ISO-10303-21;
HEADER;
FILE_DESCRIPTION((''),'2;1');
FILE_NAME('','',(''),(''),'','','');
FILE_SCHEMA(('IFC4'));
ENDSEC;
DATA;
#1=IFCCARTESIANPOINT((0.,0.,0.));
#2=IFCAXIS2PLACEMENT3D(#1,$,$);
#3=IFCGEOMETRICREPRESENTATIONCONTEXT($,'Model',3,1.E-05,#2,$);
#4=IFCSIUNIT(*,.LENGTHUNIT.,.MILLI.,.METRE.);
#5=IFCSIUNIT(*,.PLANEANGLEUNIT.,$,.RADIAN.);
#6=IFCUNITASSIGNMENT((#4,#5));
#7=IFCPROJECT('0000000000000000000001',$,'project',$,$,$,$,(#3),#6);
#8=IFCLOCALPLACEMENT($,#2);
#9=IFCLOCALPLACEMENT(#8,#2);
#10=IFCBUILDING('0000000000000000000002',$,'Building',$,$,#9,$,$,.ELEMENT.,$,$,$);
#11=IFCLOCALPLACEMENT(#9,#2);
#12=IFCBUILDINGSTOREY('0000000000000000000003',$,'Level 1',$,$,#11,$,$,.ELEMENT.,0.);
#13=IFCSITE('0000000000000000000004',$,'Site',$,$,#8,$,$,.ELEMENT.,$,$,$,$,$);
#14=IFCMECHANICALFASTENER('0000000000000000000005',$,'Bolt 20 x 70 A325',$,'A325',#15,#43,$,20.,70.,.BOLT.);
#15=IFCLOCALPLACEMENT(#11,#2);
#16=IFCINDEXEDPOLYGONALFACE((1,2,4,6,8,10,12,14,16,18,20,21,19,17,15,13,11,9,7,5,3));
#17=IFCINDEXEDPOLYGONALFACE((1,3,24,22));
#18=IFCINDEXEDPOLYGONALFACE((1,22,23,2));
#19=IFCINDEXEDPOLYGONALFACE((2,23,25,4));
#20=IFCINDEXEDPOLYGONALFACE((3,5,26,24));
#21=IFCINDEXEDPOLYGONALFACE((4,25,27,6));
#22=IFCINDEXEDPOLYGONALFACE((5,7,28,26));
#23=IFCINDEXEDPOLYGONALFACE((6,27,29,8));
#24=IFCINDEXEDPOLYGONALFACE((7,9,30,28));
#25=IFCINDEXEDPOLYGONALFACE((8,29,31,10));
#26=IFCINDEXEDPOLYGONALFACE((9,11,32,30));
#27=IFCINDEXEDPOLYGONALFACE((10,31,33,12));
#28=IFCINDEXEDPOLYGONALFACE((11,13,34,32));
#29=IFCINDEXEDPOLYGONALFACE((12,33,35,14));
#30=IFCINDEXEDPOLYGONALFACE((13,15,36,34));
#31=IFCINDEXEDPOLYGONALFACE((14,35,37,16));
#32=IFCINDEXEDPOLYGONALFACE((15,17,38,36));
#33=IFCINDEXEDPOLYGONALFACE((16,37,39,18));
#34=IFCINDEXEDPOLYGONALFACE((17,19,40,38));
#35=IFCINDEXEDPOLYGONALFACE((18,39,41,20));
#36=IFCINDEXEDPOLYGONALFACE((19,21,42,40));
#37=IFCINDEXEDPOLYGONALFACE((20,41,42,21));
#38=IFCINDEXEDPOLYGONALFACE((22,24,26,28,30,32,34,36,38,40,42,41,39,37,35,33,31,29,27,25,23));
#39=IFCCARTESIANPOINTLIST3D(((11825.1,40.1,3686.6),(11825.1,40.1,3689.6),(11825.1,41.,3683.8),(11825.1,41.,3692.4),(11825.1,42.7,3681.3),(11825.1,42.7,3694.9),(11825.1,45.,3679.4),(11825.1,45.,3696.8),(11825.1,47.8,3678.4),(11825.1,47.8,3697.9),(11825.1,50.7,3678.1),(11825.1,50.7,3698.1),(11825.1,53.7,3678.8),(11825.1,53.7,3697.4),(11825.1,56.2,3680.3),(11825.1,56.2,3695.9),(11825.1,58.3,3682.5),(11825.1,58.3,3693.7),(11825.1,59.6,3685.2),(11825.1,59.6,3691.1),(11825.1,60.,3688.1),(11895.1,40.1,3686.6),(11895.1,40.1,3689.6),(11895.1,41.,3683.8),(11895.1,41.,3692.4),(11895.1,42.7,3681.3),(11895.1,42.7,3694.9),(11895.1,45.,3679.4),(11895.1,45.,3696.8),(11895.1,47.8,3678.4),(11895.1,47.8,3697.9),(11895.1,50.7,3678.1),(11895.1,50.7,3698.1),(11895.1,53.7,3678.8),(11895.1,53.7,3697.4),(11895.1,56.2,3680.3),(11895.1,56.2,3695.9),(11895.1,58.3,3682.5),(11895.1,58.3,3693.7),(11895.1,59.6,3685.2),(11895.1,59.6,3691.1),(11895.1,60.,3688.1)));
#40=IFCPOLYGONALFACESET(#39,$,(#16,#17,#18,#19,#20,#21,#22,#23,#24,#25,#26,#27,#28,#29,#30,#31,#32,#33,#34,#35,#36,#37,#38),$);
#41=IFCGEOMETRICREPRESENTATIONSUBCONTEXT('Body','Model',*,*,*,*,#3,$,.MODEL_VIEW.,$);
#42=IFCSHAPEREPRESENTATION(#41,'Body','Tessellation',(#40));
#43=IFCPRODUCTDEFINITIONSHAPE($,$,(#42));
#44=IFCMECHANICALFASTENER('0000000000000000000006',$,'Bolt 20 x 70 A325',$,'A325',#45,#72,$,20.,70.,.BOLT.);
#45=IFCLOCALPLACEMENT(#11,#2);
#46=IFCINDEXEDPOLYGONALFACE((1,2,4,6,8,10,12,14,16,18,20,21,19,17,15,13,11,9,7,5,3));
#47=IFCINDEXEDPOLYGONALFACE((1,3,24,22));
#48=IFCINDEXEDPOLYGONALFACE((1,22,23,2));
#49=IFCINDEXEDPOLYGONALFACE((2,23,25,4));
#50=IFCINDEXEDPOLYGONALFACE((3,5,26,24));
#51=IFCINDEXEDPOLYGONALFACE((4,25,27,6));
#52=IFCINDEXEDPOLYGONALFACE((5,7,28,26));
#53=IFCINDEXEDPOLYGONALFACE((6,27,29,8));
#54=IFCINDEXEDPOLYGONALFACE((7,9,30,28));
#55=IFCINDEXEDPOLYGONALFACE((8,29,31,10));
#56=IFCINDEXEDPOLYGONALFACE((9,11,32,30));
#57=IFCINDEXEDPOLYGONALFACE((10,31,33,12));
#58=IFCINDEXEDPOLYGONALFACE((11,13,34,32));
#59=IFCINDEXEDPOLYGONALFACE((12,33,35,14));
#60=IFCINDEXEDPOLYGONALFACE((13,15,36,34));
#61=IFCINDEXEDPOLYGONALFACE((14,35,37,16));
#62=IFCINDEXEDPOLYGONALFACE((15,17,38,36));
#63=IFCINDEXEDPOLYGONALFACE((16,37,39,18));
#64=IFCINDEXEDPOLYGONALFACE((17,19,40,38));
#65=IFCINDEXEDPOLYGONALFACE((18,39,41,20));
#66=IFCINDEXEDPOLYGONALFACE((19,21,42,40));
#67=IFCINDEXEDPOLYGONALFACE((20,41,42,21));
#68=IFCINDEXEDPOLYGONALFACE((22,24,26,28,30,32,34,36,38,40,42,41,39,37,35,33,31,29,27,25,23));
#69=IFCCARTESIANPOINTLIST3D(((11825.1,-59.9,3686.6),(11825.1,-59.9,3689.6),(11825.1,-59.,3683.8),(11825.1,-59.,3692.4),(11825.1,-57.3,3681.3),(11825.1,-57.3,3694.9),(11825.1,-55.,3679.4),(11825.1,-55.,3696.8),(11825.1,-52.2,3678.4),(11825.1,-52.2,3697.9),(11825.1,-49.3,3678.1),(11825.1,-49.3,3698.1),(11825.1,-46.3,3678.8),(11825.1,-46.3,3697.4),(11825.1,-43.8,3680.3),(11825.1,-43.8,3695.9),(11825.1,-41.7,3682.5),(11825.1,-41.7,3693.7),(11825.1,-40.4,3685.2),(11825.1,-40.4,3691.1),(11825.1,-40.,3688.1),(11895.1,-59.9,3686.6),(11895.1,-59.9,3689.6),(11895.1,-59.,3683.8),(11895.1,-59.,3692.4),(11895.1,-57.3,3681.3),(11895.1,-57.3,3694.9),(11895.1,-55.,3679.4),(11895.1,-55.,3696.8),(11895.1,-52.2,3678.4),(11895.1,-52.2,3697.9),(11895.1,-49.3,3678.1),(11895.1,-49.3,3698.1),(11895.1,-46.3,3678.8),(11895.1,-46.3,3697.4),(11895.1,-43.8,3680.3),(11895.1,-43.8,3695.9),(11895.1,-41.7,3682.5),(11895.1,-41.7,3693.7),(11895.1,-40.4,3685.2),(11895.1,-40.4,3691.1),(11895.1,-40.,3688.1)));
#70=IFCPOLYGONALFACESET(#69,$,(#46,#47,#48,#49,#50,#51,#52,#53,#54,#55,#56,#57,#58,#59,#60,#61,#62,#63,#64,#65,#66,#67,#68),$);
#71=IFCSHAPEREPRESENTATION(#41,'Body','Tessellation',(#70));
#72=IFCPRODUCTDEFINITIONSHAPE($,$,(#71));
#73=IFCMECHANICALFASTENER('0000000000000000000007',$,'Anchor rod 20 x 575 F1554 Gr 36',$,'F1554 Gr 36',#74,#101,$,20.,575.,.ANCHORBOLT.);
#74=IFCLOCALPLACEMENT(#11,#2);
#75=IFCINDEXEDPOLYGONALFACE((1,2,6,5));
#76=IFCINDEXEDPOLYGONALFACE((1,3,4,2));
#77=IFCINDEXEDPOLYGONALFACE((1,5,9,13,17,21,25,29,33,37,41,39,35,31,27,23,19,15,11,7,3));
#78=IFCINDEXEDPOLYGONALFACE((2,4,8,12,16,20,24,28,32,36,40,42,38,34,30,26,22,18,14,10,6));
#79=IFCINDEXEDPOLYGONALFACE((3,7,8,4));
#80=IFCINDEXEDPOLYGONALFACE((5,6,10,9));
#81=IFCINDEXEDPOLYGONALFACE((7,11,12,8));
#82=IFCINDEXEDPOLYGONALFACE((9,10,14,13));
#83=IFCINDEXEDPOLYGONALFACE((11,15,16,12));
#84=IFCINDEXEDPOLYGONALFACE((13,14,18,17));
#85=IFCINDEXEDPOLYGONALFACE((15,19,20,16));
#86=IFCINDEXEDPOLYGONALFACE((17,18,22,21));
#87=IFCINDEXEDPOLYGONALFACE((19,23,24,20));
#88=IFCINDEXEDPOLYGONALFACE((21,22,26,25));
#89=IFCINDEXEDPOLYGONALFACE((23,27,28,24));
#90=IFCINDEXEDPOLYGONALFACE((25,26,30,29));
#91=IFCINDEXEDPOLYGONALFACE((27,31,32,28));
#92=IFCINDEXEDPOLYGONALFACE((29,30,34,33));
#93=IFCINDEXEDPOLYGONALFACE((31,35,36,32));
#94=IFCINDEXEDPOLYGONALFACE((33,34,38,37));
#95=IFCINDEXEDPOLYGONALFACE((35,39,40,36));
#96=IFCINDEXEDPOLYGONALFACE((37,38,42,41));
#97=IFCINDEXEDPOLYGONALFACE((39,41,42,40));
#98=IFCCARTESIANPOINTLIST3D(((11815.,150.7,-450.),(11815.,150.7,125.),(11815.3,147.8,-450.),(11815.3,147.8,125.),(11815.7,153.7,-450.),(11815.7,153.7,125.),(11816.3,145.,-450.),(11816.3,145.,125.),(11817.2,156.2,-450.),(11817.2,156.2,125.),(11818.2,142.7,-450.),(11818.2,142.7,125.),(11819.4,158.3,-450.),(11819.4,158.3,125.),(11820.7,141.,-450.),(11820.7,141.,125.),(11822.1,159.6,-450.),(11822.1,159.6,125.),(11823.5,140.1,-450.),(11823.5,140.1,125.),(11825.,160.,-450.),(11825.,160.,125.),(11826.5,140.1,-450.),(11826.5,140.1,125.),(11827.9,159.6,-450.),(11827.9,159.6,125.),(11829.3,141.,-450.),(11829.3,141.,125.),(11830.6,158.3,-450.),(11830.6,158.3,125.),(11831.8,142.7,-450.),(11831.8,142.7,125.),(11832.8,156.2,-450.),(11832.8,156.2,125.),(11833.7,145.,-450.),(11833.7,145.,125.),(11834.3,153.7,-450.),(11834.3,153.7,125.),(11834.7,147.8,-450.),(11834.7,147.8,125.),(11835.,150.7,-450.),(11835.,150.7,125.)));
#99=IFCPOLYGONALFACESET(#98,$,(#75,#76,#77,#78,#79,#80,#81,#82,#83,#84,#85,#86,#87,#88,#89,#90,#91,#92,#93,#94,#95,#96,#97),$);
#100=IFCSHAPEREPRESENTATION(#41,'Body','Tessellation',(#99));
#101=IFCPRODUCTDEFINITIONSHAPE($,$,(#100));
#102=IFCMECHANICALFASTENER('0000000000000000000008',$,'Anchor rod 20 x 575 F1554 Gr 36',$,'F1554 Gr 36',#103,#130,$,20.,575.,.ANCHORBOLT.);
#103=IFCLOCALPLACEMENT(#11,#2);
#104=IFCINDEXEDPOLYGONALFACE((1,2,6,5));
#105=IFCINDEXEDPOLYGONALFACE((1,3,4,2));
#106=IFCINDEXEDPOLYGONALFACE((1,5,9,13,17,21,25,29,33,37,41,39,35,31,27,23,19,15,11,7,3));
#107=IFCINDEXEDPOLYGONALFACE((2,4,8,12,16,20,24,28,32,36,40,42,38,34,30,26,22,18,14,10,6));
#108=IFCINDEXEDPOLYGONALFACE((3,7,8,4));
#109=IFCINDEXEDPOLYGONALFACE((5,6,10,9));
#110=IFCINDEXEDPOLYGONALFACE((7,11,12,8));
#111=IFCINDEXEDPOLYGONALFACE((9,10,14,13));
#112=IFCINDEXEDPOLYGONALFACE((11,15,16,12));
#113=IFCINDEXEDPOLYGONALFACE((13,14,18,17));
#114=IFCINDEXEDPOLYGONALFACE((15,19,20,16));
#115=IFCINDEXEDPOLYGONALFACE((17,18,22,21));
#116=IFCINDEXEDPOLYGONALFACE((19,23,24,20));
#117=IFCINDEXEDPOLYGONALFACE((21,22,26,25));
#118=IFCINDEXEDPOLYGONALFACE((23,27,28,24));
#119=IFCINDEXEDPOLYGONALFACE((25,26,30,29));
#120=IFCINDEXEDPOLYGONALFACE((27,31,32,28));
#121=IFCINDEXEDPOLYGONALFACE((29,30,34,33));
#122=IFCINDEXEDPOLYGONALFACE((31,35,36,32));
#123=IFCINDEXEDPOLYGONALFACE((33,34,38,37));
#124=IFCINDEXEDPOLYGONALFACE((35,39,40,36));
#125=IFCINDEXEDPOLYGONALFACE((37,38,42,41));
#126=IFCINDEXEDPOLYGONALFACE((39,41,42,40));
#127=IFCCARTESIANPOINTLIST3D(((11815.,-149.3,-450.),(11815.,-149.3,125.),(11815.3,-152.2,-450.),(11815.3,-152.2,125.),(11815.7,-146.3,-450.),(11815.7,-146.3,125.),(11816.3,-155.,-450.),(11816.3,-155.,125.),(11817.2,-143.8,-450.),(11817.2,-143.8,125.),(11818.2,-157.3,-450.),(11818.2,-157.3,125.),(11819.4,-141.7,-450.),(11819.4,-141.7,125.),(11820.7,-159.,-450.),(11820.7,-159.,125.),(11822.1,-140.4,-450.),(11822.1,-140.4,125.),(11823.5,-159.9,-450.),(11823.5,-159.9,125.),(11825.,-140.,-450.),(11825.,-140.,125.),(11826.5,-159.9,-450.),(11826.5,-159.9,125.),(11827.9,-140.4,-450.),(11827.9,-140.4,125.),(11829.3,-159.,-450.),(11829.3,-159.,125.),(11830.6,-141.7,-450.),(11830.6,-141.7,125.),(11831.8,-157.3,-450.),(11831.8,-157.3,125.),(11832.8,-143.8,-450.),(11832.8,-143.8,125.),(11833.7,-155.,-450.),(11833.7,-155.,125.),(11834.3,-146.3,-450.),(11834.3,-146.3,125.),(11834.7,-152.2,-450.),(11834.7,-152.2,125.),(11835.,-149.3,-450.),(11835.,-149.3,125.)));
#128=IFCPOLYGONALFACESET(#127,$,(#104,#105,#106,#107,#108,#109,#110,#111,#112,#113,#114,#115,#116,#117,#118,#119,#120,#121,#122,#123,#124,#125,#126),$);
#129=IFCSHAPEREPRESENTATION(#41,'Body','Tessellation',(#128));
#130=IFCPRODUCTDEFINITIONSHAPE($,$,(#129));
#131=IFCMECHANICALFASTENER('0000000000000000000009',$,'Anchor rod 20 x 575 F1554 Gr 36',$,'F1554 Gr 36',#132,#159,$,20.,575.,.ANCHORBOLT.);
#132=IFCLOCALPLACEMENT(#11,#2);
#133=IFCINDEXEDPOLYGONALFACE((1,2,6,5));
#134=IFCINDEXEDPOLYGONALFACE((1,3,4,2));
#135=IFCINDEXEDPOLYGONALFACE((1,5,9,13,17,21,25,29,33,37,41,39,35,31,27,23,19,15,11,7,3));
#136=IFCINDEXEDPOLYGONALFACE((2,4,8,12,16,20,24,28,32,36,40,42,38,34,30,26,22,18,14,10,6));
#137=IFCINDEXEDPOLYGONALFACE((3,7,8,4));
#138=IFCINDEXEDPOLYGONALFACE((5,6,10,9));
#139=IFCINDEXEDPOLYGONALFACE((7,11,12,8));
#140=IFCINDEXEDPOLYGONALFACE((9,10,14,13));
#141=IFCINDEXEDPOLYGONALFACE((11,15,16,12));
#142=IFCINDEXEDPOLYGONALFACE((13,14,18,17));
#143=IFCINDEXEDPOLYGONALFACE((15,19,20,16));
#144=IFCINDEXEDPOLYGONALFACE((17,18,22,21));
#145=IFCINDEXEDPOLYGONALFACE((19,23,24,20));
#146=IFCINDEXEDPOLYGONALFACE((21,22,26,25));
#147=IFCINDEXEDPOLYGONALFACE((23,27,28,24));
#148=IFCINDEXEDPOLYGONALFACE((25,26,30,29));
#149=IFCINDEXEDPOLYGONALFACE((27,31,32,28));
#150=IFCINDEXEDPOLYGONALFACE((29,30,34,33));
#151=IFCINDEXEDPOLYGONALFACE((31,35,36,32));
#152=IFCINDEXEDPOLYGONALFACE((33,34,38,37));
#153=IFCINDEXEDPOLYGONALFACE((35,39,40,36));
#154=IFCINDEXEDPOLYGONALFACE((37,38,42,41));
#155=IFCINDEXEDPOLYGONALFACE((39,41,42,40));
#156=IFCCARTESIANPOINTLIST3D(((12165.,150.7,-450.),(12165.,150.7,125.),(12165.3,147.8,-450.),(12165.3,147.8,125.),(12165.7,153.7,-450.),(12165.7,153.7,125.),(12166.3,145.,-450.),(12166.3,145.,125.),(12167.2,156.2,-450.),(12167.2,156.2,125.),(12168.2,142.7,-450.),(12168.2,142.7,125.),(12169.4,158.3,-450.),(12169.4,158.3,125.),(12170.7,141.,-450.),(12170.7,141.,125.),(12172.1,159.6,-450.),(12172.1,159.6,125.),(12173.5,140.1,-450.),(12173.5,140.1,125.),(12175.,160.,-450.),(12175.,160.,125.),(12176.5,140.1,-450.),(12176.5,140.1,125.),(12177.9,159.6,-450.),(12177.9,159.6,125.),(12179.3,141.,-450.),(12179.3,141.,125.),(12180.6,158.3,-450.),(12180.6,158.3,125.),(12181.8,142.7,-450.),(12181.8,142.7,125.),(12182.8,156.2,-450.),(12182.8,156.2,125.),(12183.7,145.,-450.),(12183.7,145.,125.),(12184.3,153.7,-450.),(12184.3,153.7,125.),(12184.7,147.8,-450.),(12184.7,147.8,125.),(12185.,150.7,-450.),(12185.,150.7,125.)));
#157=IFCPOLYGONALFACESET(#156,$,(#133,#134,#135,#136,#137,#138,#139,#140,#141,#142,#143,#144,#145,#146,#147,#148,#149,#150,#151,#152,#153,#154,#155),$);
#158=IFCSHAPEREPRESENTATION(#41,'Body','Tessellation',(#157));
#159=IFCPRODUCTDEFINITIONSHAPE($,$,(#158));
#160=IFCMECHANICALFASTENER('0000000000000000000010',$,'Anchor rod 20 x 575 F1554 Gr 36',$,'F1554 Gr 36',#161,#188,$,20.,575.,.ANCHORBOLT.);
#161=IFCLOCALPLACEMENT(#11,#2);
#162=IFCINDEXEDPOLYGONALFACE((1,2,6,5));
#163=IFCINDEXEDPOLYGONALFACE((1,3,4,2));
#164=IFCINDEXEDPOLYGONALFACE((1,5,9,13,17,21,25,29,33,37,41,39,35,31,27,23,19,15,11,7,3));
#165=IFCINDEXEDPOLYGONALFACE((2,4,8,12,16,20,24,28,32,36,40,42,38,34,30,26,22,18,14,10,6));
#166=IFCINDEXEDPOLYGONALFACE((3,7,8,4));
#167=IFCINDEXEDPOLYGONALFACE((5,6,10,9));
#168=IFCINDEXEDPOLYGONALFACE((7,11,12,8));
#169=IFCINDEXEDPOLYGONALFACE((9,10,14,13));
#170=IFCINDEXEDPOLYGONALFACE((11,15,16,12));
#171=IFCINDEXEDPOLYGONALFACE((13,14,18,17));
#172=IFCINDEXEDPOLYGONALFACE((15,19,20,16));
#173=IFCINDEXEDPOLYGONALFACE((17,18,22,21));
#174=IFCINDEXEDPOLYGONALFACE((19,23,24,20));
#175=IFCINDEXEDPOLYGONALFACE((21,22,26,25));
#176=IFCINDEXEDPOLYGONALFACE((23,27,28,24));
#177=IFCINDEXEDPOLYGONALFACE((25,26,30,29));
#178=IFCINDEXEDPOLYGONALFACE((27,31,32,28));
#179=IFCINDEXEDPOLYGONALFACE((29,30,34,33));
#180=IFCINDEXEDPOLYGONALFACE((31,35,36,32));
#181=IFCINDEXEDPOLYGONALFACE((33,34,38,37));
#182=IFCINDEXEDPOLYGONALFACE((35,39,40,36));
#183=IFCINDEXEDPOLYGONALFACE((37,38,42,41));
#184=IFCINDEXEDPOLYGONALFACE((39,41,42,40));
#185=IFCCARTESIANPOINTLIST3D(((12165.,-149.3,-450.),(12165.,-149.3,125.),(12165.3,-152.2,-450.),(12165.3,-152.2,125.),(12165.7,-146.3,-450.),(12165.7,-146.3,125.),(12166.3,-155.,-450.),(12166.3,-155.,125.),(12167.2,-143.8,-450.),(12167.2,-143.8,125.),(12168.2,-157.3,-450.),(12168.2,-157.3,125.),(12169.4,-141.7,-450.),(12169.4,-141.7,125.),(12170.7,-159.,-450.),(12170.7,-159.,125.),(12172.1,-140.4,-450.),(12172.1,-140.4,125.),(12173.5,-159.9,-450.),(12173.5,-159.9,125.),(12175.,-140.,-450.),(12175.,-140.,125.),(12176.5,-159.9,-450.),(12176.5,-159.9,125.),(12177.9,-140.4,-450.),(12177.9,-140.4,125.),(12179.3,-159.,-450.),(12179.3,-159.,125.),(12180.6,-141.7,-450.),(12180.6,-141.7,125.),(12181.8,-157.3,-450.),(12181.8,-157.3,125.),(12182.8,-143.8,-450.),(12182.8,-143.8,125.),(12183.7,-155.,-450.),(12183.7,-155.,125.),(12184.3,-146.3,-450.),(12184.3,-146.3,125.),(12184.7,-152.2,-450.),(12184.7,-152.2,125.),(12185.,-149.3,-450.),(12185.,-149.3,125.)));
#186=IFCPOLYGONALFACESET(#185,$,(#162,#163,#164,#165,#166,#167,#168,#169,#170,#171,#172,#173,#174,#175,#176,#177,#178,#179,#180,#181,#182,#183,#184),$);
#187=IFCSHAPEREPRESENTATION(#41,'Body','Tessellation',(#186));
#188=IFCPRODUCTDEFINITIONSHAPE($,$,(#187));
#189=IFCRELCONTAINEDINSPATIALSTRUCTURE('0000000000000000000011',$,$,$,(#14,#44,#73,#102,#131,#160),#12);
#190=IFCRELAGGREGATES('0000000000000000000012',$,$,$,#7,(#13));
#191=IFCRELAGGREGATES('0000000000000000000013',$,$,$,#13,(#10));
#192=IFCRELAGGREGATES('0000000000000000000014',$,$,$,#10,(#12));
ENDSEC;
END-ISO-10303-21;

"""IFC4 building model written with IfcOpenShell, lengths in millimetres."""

from ifc_helpers import new_model, si_unit, frame, origin, origin_2d, place, context, subcontext, project, spatial, circle, extrude, element, save


model = new_model("IFC4")

# Units and contexts
model_context = context("Model", 3, precision=1e-05, world=origin())
body_context = subcontext(model_context, "Body", "Model", "MODEL_VIEW")
ifc_project = project(units=[si_unit("LENGTHUNIT", "METRE", prefix="MILLI"), si_unit("PLANEANGLEUNIT", "RADIAN")], contexts=[model_context])

# Site, building, storey
site_placement = place(None, origin())
site = spatial("IfcSite", under=ifc_project, at=site_placement, Name="Site", CompositionType="ELEMENT")
building_placement = place(site_placement, origin())
building = spatial("IfcBuilding", under=site, at=building_placement, Name="Building", CompositionType="ELEMENT")
storey_placement = place(building_placement, origin())
storey = spatial("IfcBuildingStorey", under=building, at=storey_placement, Name="Level 1", CompositionType="ELEMENT", Elevation=0.0)

# Mechanical fasteners
for number, where, z_axis, x_axis, name in (
    (1, (11825.1, 50.0, 3688.1), (1.0, 0.0, 0.0), (0.0, 1.0, 0.0), "Bolt 20 x 70 A325"),
    (2, (11825.1, -50.0, 3688.1), (1.0, 0.0, 0.0), (0.0, 1.0, 0.0), "Bolt 20 x 70 A325"),
):
    element("IfcMechanicalFastener", number, at=place(storey_placement, frame(where, z_axis=z_axis, x_axis=x_axis)), inside=storey, Name=name, ObjectType="A325", NominalDiameter=20.0, NominalLength=70.0, PredefinedType="BOLT", context=body_context, shape_type="SweptSolid", body=[
        extrude(circle(Radius=10.0, at=origin_2d()), origin(), (0.0, 0.0, 1.0), 70.0),
    ])
for number, where, z_axis, x_axis, name in (
    (3, (11825.0, 150.0, 125.0), (0.0, 0.0, -1.0), (0.0, 1.0, 0.0), "Anchor rod 20 x 575 F1554 Gr 36"),
    (4, (11825.0, -150.0, 125.0), (0.0, 0.0, -1.0), (0.0, 1.0, 0.0), "Anchor rod 20 x 575 F1554 Gr 36"),
    (5, (12175.0, 150.0, 125.0), (0.0, 0.0, -1.0), (0.0, 1.0, 0.0), "Anchor rod 20 x 575 F1554 Gr 36"),
    (6, (12175.0, -150.0, 125.0), (0.0, 0.0, -1.0), (0.0, 1.0, 0.0), "Anchor rod 20 x 575 F1554 Gr 36"),
):
    element("IfcMechanicalFastener", number, at=place(storey_placement, frame(where, z_axis=z_axis, x_axis=x_axis)), inside=storey, Name=name, ObjectType="F1554 Gr 36", NominalDiameter=20.0, NominalLength=575.0, PredefinedType="ANCHORBOLT", context=body_context, shape_type="SweptSolid", body=[
        extrude(circle(Radius=10.0, at=origin_2d()), origin(), (0.0, 0.0, 1.0), 575.0),
    ])

save(model, "model.ifc")
